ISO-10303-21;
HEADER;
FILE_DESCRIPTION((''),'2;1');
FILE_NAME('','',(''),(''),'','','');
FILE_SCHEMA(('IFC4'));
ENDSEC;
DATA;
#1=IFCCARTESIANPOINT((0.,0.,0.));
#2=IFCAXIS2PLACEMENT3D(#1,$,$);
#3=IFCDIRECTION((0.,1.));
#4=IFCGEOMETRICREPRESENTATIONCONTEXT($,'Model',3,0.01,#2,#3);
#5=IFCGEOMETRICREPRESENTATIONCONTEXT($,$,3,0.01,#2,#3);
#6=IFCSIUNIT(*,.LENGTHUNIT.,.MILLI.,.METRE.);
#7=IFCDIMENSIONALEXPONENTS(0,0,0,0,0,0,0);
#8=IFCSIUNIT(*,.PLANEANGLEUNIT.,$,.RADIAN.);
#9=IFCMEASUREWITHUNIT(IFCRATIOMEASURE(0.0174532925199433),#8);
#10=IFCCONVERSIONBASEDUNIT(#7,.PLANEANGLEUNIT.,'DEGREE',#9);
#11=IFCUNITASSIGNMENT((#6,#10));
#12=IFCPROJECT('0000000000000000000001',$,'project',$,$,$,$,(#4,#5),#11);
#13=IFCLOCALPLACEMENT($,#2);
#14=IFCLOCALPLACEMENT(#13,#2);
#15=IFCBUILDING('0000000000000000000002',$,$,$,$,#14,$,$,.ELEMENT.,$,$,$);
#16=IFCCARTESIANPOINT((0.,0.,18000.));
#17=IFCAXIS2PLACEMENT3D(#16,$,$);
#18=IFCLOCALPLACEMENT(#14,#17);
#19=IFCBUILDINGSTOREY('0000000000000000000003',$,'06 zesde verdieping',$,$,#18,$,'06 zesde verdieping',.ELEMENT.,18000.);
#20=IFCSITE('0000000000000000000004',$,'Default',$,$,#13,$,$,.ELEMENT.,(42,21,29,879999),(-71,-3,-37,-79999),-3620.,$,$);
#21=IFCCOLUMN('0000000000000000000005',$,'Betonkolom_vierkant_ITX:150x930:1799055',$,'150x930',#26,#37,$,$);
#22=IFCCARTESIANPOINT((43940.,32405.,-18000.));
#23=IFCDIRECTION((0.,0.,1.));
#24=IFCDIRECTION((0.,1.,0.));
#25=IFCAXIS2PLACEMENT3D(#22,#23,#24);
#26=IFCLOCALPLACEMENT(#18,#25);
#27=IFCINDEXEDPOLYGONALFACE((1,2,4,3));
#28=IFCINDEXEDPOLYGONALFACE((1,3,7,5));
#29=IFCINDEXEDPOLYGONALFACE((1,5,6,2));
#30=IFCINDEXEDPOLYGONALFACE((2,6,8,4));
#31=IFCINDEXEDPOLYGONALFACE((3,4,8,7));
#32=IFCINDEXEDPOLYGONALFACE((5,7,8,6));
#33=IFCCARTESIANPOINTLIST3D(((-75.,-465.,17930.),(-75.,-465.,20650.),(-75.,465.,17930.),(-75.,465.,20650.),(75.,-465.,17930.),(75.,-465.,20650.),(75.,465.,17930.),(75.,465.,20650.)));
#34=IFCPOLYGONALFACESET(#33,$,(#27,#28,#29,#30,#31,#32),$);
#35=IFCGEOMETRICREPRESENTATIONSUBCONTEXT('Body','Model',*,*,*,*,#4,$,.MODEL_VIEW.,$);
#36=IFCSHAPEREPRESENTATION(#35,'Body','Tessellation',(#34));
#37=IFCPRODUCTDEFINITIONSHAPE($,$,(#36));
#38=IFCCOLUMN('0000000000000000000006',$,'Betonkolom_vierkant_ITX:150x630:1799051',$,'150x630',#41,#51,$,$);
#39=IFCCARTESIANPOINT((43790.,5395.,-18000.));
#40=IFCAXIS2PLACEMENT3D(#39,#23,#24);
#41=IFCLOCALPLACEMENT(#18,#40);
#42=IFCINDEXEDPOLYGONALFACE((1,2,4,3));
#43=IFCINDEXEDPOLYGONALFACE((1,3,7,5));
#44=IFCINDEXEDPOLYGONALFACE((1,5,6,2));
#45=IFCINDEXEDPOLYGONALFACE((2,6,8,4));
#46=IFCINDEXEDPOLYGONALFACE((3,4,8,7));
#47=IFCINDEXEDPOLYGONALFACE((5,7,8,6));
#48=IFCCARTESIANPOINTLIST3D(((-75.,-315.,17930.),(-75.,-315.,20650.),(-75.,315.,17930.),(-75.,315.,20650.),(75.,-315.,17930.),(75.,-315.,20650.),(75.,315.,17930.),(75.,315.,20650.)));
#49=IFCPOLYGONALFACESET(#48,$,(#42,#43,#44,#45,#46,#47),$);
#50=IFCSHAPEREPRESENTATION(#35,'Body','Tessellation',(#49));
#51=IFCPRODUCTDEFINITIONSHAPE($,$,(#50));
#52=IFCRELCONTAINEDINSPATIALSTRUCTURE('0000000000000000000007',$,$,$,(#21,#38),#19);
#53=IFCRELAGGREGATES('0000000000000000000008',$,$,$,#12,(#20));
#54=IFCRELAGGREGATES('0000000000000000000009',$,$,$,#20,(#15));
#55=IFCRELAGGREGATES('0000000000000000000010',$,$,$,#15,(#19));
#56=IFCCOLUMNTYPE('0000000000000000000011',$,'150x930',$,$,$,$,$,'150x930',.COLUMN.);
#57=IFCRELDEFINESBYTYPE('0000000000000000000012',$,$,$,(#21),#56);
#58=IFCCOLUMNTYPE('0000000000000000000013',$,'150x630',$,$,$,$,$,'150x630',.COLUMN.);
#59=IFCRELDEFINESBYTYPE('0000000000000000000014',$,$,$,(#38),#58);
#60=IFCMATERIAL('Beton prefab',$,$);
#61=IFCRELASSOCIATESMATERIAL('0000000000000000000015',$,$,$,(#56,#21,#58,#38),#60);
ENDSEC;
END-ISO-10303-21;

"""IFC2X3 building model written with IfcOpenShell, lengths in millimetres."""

from ifc_helpers import new_model, entity, si_unit, converted_unit, direction, frame, origin, origin_2d_with_axis, place, context, subcontext, project, spatial, rectangle, extrude, source, transform, mapped, material, type_object, type_shapes, element, save


model = new_model("IFC2X3")

# Units and contexts
model_context = context("Model", 3, precision=0.01, world=origin(), true_north=direction((0.0, 1.0)))
context_of_model = context(None, 3, precision=0.01, world=origin(), true_north=direction((0.0, 1.0)))
body_context = subcontext(model_context, "Body", "Model", "MODEL_VIEW")
ifc_project = project(units=[si_unit("LENGTHUNIT", "METRE", prefix="MILLI"), converted_unit("PLANEANGLEUNIT", "DEGREE", entity("IfcRatioMeasure", 0.0174532925199433), si_unit("PLANEANGLEUNIT", "RADIAN"), dimensions=[0, 0, 0, 0, 0, 0, 0])], contexts=[model_context, context_of_model])

# Site, building, storey
site_placement = place(None, origin())
site = spatial("IfcSite", under=ifc_project, at=site_placement, Name="Default", CompositionType="ELEMENT", RefLatitude=(42, 21, 29, 879999), RefLongitude=(-71, -3, -37, -79999), RefElevation=-3620.0)
building_placement = place(site_placement, origin())
building = spatial("IfcBuilding", under=site, at=building_placement, CompositionType="ELEMENT")
storey_placement = place(building_placement, frame((0.0, 0.0, 18000.0)))
storey = spatial("IfcBuildingStorey", under=building, at=storey_placement, Name="06 zesde verdieping", LongName="06 zesde verdieping", CompositionType="ELEMENT", Elevation=18000.0)

# Columns
ifc_material_1 = material(Name="Beton prefab")
column_type_1 = type_object("IfcColumnType", Name="150x930", ElementType="150x930", PredefinedType="COLUMN", material=ifc_material_1)
shared_shape_1 = source(origin(), body_context, "Body", "SweptSolid", [
    extrude(rectangle(XDim=930.0, YDim=150.0, at=origin_2d_with_axis()), frame((0.0, 0.0, 17930.0), z_axis=(0.0, 0.0, 1.0), x_axis=(0.0, -1.0, 0.0)), (0.0, 0.0, 1.0), 2720.0),
])
type_shapes(column_type_1, [shared_shape_1])
column_1_placement = place(storey_placement, frame((43940.0, 32405.0, -18000.0), z_axis=(0.0, 0.0, 1.0), x_axis=(0.0, 1.0, 0.0)))
element("IfcColumn", 1, at=column_1_placement, inside=storey, type_object=column_type_1, material=ifc_material_1, Name="Betonkolom_vierkant_ITX:150x930:1799055", ObjectType="150x930", context=body_context, shape_type="MappedRepresentation", body=[
    mapped(shared_shape_1, transform((0.0, 0.0, 0.0), scale=1.0)),
])
column_type_2 = type_object("IfcColumnType", Name="150x630", ElementType="150x630", PredefinedType="COLUMN", material=ifc_material_1)
shared_shape_2 = source(origin(), body_context, "Body", "SweptSolid", [
    extrude(rectangle(XDim=630.0, YDim=150.0, at=origin_2d_with_axis()), frame((0.0, 0.0, 17930.0), z_axis=(0.0, 0.0, 1.0), x_axis=(0.0, -1.0, 0.0)), (0.0, 0.0, 1.0), 2720.0),
])
type_shapes(column_type_2, [shared_shape_2])
column_2_placement = place(storey_placement, frame((43790.0, 5395.0, -18000.0), z_axis=(0.0, 0.0, 1.0), x_axis=(0.0, 1.0, 0.0)))
element("IfcColumn", 2, at=column_2_placement, inside=storey, type_object=column_type_2, material=ifc_material_1, Name="Betonkolom_vierkant_ITX:150x630:1799051", ObjectType="150x630", context=body_context, shape_type="MappedRepresentation", body=[
    mapped(shared_shape_2, transform((0.0, 0.0, 0.0), scale=1.0)),
])

save(model, "model.ifc")
